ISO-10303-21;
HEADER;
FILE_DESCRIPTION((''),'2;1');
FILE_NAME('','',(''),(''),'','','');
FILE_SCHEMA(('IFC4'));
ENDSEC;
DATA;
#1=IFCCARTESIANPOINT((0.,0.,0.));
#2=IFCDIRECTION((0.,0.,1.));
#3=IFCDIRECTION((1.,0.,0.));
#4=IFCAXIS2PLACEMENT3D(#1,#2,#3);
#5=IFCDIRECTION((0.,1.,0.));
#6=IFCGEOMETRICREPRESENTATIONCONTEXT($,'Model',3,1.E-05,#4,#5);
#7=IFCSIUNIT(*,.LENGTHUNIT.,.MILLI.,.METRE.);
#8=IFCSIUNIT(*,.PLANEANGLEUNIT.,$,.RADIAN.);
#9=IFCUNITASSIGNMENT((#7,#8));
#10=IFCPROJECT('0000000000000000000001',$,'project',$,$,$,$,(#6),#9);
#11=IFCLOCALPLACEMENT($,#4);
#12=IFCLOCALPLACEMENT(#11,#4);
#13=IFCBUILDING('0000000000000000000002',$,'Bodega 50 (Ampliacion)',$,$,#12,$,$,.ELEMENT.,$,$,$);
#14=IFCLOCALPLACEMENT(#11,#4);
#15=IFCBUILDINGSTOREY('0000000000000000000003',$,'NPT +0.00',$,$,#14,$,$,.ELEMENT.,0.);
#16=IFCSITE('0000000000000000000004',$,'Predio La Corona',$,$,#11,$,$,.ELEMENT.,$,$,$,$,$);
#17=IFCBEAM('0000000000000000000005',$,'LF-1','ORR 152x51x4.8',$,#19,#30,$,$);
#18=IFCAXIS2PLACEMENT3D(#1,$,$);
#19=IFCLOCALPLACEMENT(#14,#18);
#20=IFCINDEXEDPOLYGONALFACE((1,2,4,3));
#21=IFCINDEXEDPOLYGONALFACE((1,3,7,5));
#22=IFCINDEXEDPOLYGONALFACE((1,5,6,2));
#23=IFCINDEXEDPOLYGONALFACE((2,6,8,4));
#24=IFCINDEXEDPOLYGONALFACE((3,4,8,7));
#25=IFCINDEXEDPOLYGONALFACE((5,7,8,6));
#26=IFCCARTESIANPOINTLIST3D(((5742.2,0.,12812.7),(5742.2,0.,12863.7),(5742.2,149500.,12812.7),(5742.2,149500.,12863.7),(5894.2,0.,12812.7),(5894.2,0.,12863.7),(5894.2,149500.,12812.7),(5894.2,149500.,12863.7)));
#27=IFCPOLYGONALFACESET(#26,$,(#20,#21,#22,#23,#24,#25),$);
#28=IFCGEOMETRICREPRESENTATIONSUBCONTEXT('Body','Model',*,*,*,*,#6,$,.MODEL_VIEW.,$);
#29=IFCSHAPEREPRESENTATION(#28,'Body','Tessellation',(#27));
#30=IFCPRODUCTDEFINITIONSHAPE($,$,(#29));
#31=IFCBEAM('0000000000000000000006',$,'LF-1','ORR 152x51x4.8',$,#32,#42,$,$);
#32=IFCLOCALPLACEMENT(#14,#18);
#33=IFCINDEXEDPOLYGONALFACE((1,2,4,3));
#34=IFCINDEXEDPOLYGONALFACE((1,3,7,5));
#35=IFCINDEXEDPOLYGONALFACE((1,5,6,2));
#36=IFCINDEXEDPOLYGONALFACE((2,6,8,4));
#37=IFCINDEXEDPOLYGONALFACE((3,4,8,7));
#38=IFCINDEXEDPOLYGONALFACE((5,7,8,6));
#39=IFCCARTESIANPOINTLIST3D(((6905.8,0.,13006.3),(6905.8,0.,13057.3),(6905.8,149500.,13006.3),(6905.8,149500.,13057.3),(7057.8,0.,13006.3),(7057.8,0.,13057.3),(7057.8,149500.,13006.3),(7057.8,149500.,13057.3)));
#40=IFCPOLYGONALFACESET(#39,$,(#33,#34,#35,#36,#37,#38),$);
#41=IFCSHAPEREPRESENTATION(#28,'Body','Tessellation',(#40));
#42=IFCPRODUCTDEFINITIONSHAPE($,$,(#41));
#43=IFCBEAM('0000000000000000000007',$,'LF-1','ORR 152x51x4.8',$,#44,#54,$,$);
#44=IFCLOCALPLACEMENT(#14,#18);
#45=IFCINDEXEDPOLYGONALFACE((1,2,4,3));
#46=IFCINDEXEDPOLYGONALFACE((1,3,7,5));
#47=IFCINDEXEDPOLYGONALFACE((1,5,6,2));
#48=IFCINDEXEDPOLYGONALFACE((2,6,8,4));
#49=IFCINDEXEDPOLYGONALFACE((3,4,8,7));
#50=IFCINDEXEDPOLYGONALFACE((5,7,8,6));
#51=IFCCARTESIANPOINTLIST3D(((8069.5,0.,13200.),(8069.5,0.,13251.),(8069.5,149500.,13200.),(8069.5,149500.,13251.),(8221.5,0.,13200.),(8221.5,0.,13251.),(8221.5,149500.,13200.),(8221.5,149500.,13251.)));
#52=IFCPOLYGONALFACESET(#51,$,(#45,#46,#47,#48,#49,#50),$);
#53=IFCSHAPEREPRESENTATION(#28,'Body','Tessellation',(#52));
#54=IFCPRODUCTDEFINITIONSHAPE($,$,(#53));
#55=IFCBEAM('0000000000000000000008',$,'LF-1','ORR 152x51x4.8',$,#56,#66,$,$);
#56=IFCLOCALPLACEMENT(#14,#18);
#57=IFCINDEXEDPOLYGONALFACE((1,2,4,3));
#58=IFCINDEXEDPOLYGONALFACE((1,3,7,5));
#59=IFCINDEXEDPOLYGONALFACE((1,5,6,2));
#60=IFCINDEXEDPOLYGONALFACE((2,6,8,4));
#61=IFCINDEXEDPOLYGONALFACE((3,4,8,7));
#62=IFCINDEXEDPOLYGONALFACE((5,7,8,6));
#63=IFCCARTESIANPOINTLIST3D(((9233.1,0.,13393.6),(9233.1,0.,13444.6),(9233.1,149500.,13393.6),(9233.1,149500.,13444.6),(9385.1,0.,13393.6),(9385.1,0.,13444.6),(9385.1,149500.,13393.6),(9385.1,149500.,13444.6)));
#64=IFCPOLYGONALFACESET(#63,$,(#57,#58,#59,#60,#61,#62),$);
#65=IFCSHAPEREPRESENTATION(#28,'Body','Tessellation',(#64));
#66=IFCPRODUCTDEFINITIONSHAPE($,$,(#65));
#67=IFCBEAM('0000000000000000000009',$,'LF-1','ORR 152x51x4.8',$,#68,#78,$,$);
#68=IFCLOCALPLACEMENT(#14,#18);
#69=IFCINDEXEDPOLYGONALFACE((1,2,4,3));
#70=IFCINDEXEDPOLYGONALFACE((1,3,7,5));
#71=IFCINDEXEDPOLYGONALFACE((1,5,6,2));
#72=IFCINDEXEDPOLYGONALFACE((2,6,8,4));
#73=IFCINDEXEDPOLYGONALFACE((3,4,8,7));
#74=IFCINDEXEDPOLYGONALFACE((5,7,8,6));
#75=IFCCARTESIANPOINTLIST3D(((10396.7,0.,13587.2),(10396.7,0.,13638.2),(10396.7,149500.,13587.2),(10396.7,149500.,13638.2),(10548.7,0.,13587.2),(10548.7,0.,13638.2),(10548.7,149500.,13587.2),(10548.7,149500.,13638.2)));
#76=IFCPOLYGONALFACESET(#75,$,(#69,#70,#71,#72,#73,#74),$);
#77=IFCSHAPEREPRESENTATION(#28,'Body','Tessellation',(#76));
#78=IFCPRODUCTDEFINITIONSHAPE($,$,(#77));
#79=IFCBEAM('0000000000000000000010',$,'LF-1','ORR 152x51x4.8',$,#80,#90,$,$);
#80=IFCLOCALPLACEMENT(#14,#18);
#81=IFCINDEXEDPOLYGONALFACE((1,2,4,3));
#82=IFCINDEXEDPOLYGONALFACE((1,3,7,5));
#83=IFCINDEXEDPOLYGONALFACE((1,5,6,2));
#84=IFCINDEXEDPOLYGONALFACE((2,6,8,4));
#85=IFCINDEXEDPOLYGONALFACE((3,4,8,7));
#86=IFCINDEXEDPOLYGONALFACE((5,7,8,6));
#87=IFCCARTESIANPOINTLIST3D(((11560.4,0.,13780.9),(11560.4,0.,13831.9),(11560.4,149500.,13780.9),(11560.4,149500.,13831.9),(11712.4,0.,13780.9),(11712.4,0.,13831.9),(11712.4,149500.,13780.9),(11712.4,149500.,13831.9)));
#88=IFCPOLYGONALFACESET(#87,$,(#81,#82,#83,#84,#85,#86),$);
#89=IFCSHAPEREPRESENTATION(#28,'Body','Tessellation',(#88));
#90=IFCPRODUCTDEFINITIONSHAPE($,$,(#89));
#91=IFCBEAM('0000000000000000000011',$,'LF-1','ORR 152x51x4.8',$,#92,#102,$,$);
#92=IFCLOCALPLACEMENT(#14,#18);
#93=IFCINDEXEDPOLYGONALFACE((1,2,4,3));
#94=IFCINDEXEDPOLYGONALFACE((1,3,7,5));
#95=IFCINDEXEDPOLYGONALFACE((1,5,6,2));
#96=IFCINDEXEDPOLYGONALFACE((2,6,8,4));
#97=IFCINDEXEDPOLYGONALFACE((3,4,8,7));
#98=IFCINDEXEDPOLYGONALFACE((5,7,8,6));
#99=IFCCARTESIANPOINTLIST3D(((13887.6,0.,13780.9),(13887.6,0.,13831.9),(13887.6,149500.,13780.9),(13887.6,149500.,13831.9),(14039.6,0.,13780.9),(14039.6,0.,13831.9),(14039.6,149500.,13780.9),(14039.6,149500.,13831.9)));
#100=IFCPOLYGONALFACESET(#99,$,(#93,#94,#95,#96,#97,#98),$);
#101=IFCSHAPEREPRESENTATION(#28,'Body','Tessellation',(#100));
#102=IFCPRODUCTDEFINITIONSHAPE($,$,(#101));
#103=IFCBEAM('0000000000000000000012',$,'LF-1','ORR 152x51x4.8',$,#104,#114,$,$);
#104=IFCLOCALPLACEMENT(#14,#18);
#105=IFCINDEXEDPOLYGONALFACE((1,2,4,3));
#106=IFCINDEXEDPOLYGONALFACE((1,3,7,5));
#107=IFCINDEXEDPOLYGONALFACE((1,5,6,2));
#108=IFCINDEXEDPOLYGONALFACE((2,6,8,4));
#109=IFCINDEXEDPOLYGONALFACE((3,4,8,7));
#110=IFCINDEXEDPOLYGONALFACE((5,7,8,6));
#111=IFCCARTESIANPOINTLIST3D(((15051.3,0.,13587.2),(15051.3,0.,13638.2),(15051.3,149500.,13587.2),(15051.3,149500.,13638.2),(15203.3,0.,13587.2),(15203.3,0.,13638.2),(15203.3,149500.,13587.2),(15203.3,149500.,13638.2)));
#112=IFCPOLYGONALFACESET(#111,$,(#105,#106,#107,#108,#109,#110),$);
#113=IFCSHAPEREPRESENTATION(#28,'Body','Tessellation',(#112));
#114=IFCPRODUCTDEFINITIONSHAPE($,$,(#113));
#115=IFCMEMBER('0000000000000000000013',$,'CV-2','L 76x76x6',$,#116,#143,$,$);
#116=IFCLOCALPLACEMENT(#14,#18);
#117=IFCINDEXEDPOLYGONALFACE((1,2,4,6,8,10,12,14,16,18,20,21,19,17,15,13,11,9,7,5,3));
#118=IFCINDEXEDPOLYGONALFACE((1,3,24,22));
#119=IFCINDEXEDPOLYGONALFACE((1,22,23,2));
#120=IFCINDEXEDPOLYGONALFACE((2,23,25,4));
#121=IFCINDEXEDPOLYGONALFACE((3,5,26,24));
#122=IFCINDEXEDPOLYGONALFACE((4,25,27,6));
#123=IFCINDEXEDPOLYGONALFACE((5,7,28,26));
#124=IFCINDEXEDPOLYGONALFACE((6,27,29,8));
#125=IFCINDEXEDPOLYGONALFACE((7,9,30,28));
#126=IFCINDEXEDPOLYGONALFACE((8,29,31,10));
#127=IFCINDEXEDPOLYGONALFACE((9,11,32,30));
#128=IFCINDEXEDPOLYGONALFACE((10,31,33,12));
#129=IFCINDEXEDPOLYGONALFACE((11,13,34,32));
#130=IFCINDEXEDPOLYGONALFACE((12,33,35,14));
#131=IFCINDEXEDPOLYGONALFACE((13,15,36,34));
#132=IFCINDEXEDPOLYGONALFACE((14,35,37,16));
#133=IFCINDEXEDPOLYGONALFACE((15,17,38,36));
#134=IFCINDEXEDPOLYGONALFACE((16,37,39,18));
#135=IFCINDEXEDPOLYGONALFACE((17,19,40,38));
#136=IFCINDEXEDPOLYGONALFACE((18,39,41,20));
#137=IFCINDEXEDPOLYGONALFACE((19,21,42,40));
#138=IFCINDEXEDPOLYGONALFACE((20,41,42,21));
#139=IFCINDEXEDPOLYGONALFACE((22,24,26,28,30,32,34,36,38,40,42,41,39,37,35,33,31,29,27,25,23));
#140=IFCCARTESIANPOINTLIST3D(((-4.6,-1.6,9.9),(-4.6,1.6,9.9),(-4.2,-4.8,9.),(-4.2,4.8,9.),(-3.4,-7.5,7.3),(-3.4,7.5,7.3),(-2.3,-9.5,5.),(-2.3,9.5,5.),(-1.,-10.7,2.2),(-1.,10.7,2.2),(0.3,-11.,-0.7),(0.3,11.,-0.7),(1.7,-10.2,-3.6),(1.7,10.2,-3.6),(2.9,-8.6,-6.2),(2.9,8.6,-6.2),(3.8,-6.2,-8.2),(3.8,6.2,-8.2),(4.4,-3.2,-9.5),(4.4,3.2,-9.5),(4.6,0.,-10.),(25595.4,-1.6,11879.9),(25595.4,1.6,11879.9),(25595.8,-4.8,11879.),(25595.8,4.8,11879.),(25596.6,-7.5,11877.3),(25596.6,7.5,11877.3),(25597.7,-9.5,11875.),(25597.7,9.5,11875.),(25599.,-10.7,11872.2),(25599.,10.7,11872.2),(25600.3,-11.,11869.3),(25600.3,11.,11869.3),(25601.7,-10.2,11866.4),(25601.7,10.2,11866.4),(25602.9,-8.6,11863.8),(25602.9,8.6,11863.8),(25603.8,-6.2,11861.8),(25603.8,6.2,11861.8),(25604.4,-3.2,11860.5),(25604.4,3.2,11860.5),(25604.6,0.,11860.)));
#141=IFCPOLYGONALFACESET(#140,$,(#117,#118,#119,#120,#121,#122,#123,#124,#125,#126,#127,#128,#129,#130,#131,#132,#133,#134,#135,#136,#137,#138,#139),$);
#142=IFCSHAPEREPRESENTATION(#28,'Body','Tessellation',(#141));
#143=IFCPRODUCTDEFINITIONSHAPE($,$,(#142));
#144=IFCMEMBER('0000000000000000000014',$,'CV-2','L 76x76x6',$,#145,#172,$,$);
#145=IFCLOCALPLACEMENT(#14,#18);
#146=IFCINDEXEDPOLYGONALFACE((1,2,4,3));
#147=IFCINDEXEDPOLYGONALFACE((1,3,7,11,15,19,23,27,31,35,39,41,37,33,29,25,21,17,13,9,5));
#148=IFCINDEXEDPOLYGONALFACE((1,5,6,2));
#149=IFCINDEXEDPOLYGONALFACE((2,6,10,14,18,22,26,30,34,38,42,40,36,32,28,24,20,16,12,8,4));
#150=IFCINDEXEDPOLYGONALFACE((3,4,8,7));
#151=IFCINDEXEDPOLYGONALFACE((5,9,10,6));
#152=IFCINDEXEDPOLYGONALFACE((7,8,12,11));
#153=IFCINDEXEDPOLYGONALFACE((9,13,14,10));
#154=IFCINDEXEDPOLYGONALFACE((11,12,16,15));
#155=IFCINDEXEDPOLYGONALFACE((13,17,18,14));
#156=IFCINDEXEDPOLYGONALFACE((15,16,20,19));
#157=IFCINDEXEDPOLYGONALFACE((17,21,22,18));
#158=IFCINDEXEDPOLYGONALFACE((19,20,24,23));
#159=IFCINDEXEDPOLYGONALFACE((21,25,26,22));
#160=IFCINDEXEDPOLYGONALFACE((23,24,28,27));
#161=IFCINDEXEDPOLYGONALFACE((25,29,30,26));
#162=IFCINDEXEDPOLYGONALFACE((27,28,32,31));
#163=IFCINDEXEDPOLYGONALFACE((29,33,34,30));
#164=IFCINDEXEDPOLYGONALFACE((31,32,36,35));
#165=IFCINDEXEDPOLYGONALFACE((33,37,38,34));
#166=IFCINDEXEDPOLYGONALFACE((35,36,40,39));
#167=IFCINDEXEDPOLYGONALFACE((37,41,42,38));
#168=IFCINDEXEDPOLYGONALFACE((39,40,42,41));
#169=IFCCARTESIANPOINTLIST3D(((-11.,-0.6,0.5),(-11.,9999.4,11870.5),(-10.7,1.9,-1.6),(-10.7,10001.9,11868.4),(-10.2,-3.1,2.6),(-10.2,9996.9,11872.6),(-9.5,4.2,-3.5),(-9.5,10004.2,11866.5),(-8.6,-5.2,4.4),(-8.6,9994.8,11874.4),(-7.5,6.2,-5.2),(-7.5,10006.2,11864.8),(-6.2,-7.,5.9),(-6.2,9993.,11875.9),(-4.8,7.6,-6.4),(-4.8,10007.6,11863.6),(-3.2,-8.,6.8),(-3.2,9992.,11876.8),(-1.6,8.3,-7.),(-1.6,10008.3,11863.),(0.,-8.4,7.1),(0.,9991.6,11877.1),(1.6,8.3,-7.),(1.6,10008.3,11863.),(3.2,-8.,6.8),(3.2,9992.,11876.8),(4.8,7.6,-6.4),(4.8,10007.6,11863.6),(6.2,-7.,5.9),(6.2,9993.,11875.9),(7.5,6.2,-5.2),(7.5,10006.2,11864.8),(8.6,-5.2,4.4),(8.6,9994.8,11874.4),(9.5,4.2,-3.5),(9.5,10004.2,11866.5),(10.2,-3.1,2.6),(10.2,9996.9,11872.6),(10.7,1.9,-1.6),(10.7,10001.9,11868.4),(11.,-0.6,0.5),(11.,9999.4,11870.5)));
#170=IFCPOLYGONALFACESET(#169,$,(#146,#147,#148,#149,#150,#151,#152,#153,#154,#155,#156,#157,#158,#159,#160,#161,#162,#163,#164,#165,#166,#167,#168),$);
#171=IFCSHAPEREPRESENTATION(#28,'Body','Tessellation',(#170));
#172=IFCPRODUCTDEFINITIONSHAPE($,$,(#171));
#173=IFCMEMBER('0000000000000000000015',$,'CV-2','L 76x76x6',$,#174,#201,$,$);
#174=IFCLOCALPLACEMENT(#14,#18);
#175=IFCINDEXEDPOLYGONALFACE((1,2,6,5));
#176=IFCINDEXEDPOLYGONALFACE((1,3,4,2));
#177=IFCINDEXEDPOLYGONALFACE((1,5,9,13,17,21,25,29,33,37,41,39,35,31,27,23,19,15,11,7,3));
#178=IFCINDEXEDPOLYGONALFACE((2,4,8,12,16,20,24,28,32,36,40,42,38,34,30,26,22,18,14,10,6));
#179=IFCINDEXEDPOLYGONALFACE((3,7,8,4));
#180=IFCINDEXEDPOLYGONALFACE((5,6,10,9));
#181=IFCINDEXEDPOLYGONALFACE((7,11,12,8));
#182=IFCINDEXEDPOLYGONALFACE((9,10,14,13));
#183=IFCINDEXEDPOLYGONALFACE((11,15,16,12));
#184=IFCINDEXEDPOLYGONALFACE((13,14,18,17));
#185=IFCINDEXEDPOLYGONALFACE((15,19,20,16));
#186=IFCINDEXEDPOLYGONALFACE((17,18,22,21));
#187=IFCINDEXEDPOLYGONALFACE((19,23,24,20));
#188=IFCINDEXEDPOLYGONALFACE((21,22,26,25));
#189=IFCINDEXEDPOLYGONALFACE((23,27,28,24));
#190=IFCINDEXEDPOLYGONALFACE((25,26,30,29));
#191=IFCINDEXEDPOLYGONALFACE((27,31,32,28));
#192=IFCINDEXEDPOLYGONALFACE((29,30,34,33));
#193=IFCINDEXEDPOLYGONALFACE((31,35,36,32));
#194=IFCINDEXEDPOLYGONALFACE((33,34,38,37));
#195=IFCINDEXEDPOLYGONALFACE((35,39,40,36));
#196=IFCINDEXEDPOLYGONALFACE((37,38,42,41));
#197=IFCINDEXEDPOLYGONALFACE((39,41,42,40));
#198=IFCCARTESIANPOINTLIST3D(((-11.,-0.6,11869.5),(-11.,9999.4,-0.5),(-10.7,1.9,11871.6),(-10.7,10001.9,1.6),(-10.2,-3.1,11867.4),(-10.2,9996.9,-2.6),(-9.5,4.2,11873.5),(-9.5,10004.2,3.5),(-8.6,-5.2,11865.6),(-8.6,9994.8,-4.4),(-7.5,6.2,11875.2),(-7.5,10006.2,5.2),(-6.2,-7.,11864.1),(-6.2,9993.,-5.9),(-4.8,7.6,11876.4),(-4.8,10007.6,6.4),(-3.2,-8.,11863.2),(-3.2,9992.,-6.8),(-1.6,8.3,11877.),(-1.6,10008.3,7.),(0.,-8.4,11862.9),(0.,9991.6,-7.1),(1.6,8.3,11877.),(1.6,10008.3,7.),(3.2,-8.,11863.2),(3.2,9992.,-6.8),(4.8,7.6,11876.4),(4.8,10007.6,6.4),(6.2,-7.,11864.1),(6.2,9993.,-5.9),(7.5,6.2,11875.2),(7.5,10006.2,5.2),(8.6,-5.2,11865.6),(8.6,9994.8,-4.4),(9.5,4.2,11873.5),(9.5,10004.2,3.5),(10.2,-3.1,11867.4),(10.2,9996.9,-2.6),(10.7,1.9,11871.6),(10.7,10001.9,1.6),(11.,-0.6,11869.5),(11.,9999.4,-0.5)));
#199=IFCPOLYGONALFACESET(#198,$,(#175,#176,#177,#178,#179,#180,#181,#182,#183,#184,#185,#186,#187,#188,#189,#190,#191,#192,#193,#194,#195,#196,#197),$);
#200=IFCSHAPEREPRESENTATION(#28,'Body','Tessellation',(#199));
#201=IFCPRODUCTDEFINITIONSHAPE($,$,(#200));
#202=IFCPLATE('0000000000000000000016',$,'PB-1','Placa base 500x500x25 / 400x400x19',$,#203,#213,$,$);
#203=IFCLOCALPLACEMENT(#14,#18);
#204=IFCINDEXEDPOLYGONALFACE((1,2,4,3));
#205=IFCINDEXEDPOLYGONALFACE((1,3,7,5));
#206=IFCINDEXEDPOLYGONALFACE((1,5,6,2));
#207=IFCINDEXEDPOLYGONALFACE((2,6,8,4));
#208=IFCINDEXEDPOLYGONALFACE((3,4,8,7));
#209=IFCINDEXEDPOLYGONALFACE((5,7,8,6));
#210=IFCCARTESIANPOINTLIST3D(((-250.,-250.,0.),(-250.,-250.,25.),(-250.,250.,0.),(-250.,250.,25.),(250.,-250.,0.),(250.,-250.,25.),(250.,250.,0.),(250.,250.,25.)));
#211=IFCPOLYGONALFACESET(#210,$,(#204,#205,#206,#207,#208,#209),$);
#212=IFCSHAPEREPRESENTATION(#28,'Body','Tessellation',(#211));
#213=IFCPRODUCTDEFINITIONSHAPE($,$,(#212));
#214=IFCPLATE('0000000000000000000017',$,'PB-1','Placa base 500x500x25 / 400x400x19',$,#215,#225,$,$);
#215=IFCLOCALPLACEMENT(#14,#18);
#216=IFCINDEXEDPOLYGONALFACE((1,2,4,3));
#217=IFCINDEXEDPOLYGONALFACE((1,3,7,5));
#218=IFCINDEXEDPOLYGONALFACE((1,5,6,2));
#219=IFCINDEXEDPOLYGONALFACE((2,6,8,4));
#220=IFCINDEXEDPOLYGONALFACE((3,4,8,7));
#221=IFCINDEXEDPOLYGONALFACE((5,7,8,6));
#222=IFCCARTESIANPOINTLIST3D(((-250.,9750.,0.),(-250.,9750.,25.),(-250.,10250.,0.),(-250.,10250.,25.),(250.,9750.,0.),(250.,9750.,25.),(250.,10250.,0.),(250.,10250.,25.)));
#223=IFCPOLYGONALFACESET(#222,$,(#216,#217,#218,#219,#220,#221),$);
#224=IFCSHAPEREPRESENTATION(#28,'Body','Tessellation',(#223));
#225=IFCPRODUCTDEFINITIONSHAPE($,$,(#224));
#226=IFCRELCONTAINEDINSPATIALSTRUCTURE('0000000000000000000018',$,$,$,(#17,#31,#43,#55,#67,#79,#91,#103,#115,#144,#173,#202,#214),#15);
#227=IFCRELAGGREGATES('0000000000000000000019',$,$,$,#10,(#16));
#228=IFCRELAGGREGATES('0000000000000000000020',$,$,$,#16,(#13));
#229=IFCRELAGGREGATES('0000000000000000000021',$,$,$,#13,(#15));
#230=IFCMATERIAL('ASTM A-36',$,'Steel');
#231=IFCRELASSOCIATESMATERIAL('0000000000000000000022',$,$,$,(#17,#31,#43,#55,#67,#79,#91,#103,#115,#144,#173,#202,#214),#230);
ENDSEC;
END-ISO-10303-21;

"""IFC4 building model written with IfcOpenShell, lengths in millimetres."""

from ifc_helpers import new_model, si_unit, direction, frame, origin_with_axes, origin_2d, place, context, subcontext, project, spatial, rectangle, circle, extrude, material, element, save


model = new_model("IFC4")

# Units and contexts
model_context = context("Model", 3, precision=1e-05, world=origin_with_axes(), true_north=direction((0.0, 1.0, 0.0)))
body_context = subcontext(model_context, "Body", "Model", "MODEL_VIEW")
ifc_project = project(units=[si_unit("LENGTHUNIT", "METRE", prefix="MILLI"), si_unit("PLANEANGLEUNIT", "RADIAN")], contexts=[model_context])

# Site, building, storey
site_placement = place(None, origin_with_axes())
site = spatial("IfcSite", under=ifc_project, at=site_placement, Name="Predio La Corona", CompositionType="ELEMENT")
building_placement = place(site_placement, origin_with_axes())
building = spatial("IfcBuilding", under=site, at=building_placement, Name="Bodega 50 (Ampliacion)", CompositionType="ELEMENT")
storey_placement = place(site_placement, origin_with_axes())
storey = spatial("IfcBuildingStorey", under=building, at=storey_placement, Name="NPT +0.00", CompositionType="ELEMENT", Elevation=0.0)

# Shared definitions
ifc_material = material(Name="ASTM A-36", Category="Steel")

# Beams
for number, where, z_axis, x_axis, name in (
    (1, (5818.2, 0.0, 12838.2), (0.0, 1.0, 0.0), (0.0, 0.0, 1.0), "LF-1"),
    (2, (6981.8, 0.0, 13031.8), (0.0, 1.0, 0.0), (0.0, 0.0, 1.0), "LF-1"),
    (3, (8145.5, 0.0, 13225.5), (0.0, 1.0, 0.0), (0.0, 0.0, 1.0), "LF-1"),
    (4, (9309.1, 0.0, 13419.1), (0.0, 1.0, 0.0), (0.0, 0.0, 1.0), "LF-1"),
    (5, (10472.7, 0.0, 13612.7), (0.0, 1.0, 0.0), (0.0, 0.0, 1.0), "LF-1"),
    (6, (11636.4, 0.0, 13806.4), (0.0, 1.0, 0.0), (0.0, 0.0, 1.0), "LF-1"),
    (7, (13963.6, 0.0, 13806.4), (0.0, 1.0, 0.0), (0.0, 0.0, 1.0), "LF-1"),
    (8, (15127.3, 0.0, 13612.7), (0.0, 1.0, 0.0), (0.0, 0.0, 1.0), "LF-1"),
):
    element("IfcBeam", number, at=place(storey_placement, frame(where, z_axis=z_axis, x_axis=x_axis)), inside=storey, material=ifc_material, Name=name, Description="ORR 152x51x4.8", context=body_context, shape_type="SweptSolid", body=[
        extrude(rectangle(XDim=51.0, YDim=152.0, at=origin_2d()), origin_with_axes(), (0.0, 0.0, 1.0), 149500.0),
    ])

# Members
member_placement = place(storey_placement, frame((0.0, 0.0, 0.0), z_axis=(0.907222, 0.0, 0.420653), x_axis=(0.420653, 0.0, -0.907222)))
element("IfcMember", 9, at=member_placement, inside=storey, material=ifc_material, Name="CV-2", Description="L 76x76x6", context=body_context, shape_type="SweptSolid", body=[
    extrude(circle(Radius=11.0, at=origin_2d()), origin_with_axes(), (0.0, 0.0, 1.0), 28218.0),
])
for number, where, z_axis, x_axis, name in (
    (10, (0.0, 0.0, 0.0), (0.0, 0.644294, 0.764778), (0.0, -0.764778, 0.644294), "CV-2"),
    (11, (0.0, 10000.0, 0.0), (0.0, -0.644294, 0.764778), (0.0, -0.764778, -0.644294), "CV-2"),
):
    element("IfcMember", number, at=place(storey_placement, frame(where, z_axis=z_axis, x_axis=x_axis)), inside=storey, material=ifc_material, Name=name, Description="L 76x76x6", context=body_context, shape_type="SweptSolid", body=[
        extrude(circle(Radius=11.0, at=origin_2d()), origin_with_axes(), (0.0, 0.0, 1.0), 15520.9),
    ])

# Plates
for number, where, z_axis, x_axis, name in (
    (12, (0.0, 0.0, 0.0), (0.0, 0.0, 1.0), (1.0, 0.0, 0.0), "PB-1"),
    (13, (0.0, 10000.0, 0.0), (0.0, 0.0, 1.0), (1.0, 0.0, 0.0), "PB-1"),
):
    element("IfcPlate", number, at=place(storey_placement, frame(where, z_axis=z_axis, x_axis=x_axis)), inside=storey, material=ifc_material, Name=name, Description="Placa base 500x500x25 / 400x400x19", context=body_context, shape_type="SweptSolid", body=[
        extrude(rectangle(XDim=500.0, YDim=500.0, at=origin_2d()), origin_with_axes(), (0.0, 0.0, 1.0), 25.0),
    ])

save(model, "model.ifc")
